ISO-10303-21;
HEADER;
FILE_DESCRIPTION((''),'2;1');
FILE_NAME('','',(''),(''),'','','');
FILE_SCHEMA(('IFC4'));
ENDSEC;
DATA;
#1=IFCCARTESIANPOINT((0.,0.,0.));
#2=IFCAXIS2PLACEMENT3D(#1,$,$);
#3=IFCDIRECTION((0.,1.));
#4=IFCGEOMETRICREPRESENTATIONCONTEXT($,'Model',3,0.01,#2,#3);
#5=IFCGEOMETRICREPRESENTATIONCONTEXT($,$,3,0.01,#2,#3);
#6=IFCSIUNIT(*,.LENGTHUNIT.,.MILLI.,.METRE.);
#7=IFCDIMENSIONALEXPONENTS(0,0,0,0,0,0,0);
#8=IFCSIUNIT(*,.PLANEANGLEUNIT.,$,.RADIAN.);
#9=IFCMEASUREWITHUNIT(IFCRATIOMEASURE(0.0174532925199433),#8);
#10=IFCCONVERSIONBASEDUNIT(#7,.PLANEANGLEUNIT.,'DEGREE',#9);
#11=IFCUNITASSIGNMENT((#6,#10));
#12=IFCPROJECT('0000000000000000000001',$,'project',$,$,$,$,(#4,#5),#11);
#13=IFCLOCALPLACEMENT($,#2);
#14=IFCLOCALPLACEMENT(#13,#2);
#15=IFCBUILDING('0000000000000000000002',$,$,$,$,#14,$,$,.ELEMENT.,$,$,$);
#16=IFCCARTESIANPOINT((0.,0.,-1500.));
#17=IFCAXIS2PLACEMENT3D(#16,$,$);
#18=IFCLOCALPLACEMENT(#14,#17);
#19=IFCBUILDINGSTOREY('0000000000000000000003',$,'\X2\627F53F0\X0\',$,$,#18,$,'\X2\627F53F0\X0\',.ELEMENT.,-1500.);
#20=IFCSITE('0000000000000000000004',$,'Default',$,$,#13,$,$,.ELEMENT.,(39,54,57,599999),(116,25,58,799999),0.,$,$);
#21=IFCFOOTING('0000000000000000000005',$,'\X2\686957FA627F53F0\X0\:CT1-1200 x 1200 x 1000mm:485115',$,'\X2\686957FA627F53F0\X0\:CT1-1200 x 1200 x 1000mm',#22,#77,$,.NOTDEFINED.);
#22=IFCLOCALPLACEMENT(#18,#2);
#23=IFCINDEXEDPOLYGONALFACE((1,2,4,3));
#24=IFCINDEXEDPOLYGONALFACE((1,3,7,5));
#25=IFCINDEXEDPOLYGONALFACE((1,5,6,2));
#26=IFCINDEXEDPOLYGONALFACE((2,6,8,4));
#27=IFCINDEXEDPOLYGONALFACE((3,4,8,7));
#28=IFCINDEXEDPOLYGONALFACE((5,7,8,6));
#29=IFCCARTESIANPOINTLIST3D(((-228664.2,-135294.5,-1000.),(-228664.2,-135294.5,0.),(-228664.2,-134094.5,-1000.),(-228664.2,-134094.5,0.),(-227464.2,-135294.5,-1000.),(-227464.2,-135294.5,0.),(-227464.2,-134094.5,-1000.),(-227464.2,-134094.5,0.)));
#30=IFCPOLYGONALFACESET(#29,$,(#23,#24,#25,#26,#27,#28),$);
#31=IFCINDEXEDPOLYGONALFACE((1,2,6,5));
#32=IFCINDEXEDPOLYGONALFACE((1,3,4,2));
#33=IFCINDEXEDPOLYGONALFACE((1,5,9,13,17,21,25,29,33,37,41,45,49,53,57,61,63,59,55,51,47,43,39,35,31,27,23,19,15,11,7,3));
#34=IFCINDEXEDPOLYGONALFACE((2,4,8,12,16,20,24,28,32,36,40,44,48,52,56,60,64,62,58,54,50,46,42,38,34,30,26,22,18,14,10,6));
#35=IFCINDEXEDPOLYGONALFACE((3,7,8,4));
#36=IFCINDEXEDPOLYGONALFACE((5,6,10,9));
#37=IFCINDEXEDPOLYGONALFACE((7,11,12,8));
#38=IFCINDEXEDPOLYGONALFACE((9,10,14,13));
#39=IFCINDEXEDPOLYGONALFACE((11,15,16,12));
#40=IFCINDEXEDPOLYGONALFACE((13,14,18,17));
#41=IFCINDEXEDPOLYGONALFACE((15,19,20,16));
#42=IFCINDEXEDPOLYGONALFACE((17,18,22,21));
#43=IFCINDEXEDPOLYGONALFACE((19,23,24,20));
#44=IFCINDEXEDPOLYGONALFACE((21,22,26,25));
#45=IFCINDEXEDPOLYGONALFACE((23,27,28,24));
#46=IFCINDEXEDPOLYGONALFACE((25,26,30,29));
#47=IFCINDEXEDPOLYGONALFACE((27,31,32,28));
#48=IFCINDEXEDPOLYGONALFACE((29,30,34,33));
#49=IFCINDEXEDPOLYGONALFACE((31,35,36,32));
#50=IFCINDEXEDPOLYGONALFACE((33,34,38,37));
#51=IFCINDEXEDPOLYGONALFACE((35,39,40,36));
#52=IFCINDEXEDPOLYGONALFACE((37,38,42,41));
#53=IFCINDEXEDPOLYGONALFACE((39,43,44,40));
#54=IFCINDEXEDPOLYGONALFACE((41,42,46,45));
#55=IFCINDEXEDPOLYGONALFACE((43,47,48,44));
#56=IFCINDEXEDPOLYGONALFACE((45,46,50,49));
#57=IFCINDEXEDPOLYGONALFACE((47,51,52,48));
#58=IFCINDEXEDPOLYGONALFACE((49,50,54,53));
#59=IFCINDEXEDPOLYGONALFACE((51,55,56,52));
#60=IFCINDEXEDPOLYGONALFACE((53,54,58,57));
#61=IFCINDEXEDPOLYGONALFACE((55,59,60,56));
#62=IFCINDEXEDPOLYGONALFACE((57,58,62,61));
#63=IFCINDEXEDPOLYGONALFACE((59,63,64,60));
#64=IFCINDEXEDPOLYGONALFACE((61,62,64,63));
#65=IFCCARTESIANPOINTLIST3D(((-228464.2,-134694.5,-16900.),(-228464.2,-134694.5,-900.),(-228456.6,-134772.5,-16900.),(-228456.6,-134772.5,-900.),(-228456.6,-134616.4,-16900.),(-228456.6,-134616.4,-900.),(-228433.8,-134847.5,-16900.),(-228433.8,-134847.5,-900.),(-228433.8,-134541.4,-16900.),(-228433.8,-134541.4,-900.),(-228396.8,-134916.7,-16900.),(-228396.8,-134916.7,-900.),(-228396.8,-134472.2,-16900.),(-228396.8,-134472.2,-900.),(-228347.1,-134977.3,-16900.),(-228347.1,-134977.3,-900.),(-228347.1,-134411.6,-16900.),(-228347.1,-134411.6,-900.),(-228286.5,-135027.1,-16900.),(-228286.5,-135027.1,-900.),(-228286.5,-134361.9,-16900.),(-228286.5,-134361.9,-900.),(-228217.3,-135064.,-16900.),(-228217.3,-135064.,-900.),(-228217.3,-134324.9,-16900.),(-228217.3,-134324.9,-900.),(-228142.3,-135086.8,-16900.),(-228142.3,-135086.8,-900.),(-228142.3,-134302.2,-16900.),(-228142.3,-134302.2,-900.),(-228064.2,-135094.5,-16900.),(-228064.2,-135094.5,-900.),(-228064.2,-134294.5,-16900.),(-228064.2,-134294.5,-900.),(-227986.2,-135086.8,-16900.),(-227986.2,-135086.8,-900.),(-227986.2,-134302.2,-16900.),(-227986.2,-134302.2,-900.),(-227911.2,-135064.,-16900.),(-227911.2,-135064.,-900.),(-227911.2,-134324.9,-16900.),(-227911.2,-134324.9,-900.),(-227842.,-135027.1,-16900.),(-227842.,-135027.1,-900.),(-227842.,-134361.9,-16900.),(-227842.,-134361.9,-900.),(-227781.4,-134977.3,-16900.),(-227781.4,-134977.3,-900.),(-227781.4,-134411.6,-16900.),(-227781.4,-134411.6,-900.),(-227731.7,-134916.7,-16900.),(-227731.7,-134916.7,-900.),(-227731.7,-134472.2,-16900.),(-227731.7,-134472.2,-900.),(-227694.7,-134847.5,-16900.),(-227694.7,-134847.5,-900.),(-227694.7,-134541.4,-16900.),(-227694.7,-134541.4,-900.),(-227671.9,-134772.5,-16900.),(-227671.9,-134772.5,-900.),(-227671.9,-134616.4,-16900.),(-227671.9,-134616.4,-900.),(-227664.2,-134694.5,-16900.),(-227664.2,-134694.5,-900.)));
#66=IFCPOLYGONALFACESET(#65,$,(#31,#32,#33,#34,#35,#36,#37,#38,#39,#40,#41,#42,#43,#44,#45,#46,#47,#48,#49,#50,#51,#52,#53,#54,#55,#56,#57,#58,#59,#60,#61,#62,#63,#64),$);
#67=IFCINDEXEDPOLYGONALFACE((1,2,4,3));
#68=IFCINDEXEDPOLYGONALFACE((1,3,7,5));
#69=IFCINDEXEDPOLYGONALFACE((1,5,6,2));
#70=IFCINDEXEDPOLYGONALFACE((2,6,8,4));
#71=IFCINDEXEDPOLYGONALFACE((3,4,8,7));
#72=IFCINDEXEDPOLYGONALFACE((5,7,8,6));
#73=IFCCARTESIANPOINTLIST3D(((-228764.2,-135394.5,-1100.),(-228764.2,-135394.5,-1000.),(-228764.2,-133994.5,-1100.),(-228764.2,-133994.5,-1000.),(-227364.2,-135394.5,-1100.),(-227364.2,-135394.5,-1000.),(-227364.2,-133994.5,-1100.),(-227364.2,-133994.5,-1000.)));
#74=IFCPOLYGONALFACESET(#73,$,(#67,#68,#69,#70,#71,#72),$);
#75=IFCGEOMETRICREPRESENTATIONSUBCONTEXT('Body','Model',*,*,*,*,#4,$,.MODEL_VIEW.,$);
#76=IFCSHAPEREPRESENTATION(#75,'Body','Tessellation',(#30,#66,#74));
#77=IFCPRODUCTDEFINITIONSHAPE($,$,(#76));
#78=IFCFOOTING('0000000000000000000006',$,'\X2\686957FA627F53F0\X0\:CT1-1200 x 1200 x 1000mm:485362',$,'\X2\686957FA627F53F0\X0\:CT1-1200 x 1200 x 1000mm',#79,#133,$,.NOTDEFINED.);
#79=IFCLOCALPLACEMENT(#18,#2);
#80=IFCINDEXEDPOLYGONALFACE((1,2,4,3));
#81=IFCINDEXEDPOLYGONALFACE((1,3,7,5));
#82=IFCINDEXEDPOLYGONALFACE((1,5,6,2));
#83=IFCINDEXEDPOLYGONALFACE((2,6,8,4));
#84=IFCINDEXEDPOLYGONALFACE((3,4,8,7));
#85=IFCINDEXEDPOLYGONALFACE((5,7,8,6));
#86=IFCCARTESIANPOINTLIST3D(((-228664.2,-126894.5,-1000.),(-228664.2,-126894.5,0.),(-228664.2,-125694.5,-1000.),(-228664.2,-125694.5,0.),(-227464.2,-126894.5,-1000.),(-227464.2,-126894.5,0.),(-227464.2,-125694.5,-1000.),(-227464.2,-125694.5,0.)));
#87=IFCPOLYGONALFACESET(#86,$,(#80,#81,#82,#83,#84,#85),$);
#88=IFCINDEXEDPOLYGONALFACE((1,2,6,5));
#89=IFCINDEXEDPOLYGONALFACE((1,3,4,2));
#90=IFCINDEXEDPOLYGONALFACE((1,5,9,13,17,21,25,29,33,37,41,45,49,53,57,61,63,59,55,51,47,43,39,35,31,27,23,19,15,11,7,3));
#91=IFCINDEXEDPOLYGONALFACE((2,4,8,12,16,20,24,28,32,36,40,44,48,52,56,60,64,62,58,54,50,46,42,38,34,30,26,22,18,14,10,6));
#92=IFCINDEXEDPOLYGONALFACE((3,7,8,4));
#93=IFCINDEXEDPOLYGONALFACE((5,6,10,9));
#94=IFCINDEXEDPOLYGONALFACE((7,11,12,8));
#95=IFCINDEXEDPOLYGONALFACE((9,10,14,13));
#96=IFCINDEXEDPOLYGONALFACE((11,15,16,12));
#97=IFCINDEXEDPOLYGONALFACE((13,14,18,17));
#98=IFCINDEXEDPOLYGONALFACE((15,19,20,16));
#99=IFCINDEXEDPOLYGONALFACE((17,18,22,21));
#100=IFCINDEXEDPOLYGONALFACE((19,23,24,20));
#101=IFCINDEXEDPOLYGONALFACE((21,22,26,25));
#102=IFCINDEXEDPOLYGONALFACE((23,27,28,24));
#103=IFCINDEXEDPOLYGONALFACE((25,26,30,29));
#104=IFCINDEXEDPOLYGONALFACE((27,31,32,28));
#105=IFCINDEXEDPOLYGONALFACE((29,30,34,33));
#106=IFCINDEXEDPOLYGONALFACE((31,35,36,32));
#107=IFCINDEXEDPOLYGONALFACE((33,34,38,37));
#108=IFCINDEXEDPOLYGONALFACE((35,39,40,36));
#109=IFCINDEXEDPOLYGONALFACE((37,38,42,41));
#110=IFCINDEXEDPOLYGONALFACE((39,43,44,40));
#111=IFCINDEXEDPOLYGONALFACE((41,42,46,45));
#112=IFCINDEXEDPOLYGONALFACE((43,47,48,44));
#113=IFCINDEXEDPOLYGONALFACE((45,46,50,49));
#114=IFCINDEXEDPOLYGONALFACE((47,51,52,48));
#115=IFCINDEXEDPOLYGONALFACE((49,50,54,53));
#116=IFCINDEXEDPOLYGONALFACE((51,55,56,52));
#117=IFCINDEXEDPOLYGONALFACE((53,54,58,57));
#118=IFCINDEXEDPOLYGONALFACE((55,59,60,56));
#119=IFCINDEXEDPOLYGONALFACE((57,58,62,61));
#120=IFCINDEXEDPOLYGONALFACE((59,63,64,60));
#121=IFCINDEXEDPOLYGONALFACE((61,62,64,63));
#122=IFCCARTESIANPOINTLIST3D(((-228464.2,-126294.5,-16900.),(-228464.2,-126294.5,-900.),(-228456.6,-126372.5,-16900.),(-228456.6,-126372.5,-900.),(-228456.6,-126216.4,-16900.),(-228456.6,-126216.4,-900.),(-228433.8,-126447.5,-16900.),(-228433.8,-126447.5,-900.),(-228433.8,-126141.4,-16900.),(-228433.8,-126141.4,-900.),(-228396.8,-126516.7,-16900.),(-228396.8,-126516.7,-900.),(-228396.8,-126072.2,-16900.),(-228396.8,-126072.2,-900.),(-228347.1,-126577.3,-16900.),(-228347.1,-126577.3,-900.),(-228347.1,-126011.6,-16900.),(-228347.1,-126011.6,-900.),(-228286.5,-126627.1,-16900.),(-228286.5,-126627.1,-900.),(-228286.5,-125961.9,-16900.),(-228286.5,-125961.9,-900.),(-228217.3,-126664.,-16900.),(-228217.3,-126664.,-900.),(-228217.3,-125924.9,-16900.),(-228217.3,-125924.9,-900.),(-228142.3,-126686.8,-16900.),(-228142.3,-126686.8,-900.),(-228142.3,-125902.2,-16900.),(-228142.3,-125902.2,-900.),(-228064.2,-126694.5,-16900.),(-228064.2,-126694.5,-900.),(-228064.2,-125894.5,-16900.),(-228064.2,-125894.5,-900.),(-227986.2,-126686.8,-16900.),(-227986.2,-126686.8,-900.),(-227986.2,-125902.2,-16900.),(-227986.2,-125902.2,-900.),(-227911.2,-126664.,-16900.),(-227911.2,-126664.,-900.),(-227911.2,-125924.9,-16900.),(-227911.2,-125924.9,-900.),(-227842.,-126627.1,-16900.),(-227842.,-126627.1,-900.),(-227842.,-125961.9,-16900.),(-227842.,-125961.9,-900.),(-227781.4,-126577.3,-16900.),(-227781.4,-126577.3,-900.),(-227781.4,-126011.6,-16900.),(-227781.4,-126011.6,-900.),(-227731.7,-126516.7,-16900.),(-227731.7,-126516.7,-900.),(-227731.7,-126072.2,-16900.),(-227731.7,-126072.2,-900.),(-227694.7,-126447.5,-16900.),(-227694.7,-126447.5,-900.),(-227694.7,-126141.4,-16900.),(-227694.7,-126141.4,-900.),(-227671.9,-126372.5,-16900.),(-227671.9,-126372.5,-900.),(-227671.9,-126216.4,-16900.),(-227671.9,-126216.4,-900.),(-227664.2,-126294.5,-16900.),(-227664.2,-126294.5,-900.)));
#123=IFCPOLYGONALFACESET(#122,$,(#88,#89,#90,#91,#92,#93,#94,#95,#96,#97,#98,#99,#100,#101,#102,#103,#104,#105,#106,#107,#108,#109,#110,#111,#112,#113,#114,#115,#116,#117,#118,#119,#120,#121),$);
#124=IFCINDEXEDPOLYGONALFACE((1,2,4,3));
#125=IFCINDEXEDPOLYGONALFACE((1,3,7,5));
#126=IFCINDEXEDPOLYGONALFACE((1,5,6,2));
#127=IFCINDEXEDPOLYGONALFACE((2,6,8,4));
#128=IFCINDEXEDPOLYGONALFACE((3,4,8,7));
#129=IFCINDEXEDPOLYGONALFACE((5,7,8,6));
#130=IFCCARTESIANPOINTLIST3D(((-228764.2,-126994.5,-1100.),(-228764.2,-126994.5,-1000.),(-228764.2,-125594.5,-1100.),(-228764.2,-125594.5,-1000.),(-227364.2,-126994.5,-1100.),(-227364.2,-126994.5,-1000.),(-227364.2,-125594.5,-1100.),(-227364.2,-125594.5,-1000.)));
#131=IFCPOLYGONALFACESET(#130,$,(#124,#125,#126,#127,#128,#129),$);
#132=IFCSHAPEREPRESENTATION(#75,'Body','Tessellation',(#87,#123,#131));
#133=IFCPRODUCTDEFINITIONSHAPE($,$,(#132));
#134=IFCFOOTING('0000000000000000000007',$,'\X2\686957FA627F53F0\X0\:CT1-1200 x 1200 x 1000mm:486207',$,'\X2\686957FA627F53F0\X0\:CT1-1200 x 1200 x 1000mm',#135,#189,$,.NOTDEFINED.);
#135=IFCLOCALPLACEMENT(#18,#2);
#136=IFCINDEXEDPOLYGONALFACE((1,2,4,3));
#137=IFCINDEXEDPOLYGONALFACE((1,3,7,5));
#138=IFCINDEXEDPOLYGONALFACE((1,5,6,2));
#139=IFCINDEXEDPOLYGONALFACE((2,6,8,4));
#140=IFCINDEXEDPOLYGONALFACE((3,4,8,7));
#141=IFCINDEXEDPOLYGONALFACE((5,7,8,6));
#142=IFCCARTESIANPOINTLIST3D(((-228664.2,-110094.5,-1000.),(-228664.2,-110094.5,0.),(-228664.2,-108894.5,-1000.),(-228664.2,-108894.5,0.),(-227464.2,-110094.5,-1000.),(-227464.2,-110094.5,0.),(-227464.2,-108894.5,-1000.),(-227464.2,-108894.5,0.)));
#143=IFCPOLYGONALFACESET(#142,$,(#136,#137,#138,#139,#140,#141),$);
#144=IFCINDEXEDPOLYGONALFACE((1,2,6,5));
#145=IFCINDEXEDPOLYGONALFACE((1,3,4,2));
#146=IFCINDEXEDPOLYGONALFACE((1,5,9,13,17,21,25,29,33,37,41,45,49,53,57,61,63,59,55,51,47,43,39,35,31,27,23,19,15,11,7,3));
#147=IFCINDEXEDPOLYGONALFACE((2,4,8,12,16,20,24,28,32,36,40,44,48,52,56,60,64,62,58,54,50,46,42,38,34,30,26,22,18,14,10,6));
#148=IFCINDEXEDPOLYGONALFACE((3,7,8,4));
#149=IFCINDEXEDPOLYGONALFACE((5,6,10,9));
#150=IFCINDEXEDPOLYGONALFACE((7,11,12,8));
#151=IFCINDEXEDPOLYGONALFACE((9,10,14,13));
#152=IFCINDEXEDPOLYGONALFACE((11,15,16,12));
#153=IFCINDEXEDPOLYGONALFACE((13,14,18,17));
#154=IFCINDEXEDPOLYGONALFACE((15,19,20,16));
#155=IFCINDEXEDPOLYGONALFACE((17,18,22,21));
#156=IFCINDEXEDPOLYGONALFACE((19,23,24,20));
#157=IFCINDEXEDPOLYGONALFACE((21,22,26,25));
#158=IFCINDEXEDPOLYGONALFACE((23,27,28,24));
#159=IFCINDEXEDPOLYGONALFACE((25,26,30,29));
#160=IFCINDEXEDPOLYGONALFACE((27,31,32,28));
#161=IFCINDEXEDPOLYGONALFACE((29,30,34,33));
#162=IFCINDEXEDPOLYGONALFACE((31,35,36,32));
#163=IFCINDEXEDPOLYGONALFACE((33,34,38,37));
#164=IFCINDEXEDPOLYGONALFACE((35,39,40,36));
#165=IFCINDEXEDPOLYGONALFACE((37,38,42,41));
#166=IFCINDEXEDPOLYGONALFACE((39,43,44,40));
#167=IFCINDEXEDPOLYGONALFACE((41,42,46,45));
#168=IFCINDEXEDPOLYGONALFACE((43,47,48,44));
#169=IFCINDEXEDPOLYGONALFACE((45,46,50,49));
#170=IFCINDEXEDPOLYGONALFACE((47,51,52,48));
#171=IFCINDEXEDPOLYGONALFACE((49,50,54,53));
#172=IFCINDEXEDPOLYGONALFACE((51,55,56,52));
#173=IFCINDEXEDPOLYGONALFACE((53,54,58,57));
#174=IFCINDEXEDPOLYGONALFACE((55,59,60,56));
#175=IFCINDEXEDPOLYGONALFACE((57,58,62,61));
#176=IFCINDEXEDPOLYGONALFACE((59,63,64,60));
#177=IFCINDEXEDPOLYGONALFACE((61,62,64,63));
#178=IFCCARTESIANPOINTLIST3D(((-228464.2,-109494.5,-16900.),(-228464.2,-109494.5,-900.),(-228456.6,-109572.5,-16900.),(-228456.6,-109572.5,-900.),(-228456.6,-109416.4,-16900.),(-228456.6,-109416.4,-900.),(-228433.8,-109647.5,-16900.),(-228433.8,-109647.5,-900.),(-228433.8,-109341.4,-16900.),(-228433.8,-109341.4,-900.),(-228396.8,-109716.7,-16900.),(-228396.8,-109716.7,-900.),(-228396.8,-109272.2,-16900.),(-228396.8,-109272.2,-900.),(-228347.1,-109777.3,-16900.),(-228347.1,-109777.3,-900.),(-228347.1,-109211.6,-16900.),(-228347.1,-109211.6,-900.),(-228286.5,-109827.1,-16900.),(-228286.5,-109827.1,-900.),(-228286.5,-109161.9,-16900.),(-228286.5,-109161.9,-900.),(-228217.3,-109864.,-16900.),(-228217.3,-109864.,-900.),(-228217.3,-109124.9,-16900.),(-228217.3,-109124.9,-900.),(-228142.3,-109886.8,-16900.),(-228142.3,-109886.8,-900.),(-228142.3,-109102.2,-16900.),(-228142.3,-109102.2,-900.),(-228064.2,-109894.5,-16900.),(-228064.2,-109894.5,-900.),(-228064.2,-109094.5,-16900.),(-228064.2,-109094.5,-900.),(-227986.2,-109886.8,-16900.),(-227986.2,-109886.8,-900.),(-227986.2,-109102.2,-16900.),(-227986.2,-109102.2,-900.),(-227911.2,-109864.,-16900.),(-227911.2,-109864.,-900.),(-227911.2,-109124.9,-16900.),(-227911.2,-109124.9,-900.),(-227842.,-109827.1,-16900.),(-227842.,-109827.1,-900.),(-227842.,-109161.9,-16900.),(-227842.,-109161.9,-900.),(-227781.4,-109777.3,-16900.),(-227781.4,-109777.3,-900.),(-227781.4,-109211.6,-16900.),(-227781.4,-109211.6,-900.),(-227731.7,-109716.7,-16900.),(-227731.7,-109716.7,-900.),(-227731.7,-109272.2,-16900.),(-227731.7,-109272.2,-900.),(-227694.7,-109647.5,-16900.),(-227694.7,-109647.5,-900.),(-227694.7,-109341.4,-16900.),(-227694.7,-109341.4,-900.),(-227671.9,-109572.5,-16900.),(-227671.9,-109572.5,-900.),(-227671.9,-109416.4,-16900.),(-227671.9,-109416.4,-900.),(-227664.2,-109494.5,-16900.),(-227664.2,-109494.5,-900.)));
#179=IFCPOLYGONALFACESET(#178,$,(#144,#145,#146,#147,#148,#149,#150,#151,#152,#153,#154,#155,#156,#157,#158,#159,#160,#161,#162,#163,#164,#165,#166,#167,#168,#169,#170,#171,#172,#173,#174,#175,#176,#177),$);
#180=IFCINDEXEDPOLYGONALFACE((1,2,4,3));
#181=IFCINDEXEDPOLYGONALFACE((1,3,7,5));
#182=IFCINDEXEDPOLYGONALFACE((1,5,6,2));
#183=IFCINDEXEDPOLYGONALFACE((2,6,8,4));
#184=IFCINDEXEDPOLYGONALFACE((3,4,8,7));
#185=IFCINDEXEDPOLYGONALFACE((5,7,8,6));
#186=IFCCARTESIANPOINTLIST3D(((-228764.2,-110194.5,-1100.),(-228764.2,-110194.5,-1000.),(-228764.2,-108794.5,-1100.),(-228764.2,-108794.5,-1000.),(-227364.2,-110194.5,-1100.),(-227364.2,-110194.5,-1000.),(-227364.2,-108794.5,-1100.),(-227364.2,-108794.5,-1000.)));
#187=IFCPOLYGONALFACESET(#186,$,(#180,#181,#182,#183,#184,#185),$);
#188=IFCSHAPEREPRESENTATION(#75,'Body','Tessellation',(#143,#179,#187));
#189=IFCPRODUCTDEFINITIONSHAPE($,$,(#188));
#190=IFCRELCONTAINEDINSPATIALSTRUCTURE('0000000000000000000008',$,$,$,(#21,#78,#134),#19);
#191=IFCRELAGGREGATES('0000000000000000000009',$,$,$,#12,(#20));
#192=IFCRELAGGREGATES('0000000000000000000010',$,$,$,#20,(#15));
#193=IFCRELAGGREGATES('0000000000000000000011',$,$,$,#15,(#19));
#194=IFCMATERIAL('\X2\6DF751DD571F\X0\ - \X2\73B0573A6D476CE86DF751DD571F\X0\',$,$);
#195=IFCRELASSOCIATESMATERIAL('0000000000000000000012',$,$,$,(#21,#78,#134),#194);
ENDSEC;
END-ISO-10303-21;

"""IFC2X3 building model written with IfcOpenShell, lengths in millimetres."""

from ifc_helpers import new_model, entity, si_unit, converted_unit, direction, frame, frame_2d, origin, origin_2d_with_axis, place, context, subcontext, project, spatial, rectangle, circle, extrude, material, element, save


model = new_model("IFC2X3")

# Units and contexts
model_context = context("Model", 3, precision=0.01, world=origin(), true_north=direction((0.0, 1.0)))
context_of_model = context(None, 3, precision=0.01, world=origin(), true_north=direction((0.0, 1.0)))
body_context = subcontext(model_context, "Body", "Model", "MODEL_VIEW")
ifc_project = project(units=[si_unit("LENGTHUNIT", "METRE", prefix="MILLI"), converted_unit("PLANEANGLEUNIT", "DEGREE", entity("IfcRatioMeasure", 0.0174532925199433), si_unit("PLANEANGLEUNIT", "RADIAN"), dimensions=[0, 0, 0, 0, 0, 0, 0])], contexts=[model_context, context_of_model])

# Site, building, storey
site_placement = place(None, origin())
site = spatial("IfcSite", under=ifc_project, at=site_placement, Name="Default", CompositionType="ELEMENT", RefLatitude=(39, 54, 57, 599999), RefLongitude=(116, 25, 58, 799999), RefElevation=0.0)
building_placement = place(site_placement, origin())
building = spatial("IfcBuilding", under=site, at=building_placement, CompositionType="ELEMENT")
storey_placement = place(building_placement, frame((0.0, 0.0, -1500.0)))
storey = spatial("IfcBuildingStorey", under=building, at=storey_placement, Name="承台", LongName="承台", CompositionType="ELEMENT", Elevation=-1500.0)

# Footings
ifc_material_1 = material(Name="混凝土 - 现场浇注混凝土")
footing_1_placement = place(storey_placement, frame((-228764.2, -135394.5, -16900.0)))
element("IfcFooting", 1, at=footing_1_placement, inside=storey, material=ifc_material_1, Name="桩基承台:CT1-1200 x 1200 x 1000mm:485115", ObjectType="桩基承台:CT1-1200 x 1200 x 1000mm", PredefinedType="NOTDEFINED", context=body_context, shape_type="SweptSolid", body=[
    extrude(rectangle(XDim=1200.0, YDim=1200.0, at=origin_2d_with_axis()), frame((700.0, 700.0, 15900.0), z_axis=(0.0, 0.0, 1.0), x_axis=(-1.0, 0.0, 0.0)), (0.0, 0.0, 1.0), 1000.0),
    extrude(circle(Radius=400.0, at=origin_2d_with_axis()), frame((700.0, 700.0, 0.0)), (0.0, 0.0, 1.0), 16000.0),
    extrude(rectangle(XDim=1400.0, YDim=1400.0, at=frame_2d((0.0, 0.0), x_axis=(1.0, 0.0))), frame((700.0, 700.0, 15800.0), z_axis=(0.0, 0.0, 1.0), x_axis=(0.0, 1.0, 0.0)), (0.0, 0.0, 1.0), 100.0),
])
for number, where, name in (
    (2, (-228764.2, -126994.5, -16900.0), "桩基承台:CT1-1200 x 1200 x 1000mm:485362"),
    (3, (-228764.2, -110194.5, -16900.0), "桩基承台:CT1-1200 x 1200 x 1000mm:486207"),
):
    element("IfcFooting", number, at=place(storey_placement, frame(where)), inside=storey, material=ifc_material_1, Name=name, ObjectType="桩基承台:CT1-1200 x 1200 x 1000mm", PredefinedType="NOTDEFINED", context=body_context, shape_type="SweptSolid", body=[
        extrude(rectangle(XDim=1200.0, YDim=1200.0, at=origin_2d_with_axis()), frame((700.0, 700.0, 15900.0), z_axis=(0.0, 0.0, 1.0), x_axis=(-1.0, 0.0, 0.0)), (0.0, 0.0, 1.0), 1000.0),
        extrude(circle(Radius=400.0, at=origin_2d_with_axis()), frame((700.0, 700.0, 0.0)), (0.0, 0.0, 1.0), 16000.0),
        extrude(rectangle(XDim=1400.0, YDim=1400.0, at=frame_2d((0.0, 0.0), x_axis=(1.0, 0.0))), frame((700.0, 700.0, 15800.0), z_axis=(0.0, 0.0, 1.0), x_axis=(0.0, 1.0, 0.0)), (0.0, 0.0, 1.0), 100.0),
    ])

save(model, "model.ifc")
